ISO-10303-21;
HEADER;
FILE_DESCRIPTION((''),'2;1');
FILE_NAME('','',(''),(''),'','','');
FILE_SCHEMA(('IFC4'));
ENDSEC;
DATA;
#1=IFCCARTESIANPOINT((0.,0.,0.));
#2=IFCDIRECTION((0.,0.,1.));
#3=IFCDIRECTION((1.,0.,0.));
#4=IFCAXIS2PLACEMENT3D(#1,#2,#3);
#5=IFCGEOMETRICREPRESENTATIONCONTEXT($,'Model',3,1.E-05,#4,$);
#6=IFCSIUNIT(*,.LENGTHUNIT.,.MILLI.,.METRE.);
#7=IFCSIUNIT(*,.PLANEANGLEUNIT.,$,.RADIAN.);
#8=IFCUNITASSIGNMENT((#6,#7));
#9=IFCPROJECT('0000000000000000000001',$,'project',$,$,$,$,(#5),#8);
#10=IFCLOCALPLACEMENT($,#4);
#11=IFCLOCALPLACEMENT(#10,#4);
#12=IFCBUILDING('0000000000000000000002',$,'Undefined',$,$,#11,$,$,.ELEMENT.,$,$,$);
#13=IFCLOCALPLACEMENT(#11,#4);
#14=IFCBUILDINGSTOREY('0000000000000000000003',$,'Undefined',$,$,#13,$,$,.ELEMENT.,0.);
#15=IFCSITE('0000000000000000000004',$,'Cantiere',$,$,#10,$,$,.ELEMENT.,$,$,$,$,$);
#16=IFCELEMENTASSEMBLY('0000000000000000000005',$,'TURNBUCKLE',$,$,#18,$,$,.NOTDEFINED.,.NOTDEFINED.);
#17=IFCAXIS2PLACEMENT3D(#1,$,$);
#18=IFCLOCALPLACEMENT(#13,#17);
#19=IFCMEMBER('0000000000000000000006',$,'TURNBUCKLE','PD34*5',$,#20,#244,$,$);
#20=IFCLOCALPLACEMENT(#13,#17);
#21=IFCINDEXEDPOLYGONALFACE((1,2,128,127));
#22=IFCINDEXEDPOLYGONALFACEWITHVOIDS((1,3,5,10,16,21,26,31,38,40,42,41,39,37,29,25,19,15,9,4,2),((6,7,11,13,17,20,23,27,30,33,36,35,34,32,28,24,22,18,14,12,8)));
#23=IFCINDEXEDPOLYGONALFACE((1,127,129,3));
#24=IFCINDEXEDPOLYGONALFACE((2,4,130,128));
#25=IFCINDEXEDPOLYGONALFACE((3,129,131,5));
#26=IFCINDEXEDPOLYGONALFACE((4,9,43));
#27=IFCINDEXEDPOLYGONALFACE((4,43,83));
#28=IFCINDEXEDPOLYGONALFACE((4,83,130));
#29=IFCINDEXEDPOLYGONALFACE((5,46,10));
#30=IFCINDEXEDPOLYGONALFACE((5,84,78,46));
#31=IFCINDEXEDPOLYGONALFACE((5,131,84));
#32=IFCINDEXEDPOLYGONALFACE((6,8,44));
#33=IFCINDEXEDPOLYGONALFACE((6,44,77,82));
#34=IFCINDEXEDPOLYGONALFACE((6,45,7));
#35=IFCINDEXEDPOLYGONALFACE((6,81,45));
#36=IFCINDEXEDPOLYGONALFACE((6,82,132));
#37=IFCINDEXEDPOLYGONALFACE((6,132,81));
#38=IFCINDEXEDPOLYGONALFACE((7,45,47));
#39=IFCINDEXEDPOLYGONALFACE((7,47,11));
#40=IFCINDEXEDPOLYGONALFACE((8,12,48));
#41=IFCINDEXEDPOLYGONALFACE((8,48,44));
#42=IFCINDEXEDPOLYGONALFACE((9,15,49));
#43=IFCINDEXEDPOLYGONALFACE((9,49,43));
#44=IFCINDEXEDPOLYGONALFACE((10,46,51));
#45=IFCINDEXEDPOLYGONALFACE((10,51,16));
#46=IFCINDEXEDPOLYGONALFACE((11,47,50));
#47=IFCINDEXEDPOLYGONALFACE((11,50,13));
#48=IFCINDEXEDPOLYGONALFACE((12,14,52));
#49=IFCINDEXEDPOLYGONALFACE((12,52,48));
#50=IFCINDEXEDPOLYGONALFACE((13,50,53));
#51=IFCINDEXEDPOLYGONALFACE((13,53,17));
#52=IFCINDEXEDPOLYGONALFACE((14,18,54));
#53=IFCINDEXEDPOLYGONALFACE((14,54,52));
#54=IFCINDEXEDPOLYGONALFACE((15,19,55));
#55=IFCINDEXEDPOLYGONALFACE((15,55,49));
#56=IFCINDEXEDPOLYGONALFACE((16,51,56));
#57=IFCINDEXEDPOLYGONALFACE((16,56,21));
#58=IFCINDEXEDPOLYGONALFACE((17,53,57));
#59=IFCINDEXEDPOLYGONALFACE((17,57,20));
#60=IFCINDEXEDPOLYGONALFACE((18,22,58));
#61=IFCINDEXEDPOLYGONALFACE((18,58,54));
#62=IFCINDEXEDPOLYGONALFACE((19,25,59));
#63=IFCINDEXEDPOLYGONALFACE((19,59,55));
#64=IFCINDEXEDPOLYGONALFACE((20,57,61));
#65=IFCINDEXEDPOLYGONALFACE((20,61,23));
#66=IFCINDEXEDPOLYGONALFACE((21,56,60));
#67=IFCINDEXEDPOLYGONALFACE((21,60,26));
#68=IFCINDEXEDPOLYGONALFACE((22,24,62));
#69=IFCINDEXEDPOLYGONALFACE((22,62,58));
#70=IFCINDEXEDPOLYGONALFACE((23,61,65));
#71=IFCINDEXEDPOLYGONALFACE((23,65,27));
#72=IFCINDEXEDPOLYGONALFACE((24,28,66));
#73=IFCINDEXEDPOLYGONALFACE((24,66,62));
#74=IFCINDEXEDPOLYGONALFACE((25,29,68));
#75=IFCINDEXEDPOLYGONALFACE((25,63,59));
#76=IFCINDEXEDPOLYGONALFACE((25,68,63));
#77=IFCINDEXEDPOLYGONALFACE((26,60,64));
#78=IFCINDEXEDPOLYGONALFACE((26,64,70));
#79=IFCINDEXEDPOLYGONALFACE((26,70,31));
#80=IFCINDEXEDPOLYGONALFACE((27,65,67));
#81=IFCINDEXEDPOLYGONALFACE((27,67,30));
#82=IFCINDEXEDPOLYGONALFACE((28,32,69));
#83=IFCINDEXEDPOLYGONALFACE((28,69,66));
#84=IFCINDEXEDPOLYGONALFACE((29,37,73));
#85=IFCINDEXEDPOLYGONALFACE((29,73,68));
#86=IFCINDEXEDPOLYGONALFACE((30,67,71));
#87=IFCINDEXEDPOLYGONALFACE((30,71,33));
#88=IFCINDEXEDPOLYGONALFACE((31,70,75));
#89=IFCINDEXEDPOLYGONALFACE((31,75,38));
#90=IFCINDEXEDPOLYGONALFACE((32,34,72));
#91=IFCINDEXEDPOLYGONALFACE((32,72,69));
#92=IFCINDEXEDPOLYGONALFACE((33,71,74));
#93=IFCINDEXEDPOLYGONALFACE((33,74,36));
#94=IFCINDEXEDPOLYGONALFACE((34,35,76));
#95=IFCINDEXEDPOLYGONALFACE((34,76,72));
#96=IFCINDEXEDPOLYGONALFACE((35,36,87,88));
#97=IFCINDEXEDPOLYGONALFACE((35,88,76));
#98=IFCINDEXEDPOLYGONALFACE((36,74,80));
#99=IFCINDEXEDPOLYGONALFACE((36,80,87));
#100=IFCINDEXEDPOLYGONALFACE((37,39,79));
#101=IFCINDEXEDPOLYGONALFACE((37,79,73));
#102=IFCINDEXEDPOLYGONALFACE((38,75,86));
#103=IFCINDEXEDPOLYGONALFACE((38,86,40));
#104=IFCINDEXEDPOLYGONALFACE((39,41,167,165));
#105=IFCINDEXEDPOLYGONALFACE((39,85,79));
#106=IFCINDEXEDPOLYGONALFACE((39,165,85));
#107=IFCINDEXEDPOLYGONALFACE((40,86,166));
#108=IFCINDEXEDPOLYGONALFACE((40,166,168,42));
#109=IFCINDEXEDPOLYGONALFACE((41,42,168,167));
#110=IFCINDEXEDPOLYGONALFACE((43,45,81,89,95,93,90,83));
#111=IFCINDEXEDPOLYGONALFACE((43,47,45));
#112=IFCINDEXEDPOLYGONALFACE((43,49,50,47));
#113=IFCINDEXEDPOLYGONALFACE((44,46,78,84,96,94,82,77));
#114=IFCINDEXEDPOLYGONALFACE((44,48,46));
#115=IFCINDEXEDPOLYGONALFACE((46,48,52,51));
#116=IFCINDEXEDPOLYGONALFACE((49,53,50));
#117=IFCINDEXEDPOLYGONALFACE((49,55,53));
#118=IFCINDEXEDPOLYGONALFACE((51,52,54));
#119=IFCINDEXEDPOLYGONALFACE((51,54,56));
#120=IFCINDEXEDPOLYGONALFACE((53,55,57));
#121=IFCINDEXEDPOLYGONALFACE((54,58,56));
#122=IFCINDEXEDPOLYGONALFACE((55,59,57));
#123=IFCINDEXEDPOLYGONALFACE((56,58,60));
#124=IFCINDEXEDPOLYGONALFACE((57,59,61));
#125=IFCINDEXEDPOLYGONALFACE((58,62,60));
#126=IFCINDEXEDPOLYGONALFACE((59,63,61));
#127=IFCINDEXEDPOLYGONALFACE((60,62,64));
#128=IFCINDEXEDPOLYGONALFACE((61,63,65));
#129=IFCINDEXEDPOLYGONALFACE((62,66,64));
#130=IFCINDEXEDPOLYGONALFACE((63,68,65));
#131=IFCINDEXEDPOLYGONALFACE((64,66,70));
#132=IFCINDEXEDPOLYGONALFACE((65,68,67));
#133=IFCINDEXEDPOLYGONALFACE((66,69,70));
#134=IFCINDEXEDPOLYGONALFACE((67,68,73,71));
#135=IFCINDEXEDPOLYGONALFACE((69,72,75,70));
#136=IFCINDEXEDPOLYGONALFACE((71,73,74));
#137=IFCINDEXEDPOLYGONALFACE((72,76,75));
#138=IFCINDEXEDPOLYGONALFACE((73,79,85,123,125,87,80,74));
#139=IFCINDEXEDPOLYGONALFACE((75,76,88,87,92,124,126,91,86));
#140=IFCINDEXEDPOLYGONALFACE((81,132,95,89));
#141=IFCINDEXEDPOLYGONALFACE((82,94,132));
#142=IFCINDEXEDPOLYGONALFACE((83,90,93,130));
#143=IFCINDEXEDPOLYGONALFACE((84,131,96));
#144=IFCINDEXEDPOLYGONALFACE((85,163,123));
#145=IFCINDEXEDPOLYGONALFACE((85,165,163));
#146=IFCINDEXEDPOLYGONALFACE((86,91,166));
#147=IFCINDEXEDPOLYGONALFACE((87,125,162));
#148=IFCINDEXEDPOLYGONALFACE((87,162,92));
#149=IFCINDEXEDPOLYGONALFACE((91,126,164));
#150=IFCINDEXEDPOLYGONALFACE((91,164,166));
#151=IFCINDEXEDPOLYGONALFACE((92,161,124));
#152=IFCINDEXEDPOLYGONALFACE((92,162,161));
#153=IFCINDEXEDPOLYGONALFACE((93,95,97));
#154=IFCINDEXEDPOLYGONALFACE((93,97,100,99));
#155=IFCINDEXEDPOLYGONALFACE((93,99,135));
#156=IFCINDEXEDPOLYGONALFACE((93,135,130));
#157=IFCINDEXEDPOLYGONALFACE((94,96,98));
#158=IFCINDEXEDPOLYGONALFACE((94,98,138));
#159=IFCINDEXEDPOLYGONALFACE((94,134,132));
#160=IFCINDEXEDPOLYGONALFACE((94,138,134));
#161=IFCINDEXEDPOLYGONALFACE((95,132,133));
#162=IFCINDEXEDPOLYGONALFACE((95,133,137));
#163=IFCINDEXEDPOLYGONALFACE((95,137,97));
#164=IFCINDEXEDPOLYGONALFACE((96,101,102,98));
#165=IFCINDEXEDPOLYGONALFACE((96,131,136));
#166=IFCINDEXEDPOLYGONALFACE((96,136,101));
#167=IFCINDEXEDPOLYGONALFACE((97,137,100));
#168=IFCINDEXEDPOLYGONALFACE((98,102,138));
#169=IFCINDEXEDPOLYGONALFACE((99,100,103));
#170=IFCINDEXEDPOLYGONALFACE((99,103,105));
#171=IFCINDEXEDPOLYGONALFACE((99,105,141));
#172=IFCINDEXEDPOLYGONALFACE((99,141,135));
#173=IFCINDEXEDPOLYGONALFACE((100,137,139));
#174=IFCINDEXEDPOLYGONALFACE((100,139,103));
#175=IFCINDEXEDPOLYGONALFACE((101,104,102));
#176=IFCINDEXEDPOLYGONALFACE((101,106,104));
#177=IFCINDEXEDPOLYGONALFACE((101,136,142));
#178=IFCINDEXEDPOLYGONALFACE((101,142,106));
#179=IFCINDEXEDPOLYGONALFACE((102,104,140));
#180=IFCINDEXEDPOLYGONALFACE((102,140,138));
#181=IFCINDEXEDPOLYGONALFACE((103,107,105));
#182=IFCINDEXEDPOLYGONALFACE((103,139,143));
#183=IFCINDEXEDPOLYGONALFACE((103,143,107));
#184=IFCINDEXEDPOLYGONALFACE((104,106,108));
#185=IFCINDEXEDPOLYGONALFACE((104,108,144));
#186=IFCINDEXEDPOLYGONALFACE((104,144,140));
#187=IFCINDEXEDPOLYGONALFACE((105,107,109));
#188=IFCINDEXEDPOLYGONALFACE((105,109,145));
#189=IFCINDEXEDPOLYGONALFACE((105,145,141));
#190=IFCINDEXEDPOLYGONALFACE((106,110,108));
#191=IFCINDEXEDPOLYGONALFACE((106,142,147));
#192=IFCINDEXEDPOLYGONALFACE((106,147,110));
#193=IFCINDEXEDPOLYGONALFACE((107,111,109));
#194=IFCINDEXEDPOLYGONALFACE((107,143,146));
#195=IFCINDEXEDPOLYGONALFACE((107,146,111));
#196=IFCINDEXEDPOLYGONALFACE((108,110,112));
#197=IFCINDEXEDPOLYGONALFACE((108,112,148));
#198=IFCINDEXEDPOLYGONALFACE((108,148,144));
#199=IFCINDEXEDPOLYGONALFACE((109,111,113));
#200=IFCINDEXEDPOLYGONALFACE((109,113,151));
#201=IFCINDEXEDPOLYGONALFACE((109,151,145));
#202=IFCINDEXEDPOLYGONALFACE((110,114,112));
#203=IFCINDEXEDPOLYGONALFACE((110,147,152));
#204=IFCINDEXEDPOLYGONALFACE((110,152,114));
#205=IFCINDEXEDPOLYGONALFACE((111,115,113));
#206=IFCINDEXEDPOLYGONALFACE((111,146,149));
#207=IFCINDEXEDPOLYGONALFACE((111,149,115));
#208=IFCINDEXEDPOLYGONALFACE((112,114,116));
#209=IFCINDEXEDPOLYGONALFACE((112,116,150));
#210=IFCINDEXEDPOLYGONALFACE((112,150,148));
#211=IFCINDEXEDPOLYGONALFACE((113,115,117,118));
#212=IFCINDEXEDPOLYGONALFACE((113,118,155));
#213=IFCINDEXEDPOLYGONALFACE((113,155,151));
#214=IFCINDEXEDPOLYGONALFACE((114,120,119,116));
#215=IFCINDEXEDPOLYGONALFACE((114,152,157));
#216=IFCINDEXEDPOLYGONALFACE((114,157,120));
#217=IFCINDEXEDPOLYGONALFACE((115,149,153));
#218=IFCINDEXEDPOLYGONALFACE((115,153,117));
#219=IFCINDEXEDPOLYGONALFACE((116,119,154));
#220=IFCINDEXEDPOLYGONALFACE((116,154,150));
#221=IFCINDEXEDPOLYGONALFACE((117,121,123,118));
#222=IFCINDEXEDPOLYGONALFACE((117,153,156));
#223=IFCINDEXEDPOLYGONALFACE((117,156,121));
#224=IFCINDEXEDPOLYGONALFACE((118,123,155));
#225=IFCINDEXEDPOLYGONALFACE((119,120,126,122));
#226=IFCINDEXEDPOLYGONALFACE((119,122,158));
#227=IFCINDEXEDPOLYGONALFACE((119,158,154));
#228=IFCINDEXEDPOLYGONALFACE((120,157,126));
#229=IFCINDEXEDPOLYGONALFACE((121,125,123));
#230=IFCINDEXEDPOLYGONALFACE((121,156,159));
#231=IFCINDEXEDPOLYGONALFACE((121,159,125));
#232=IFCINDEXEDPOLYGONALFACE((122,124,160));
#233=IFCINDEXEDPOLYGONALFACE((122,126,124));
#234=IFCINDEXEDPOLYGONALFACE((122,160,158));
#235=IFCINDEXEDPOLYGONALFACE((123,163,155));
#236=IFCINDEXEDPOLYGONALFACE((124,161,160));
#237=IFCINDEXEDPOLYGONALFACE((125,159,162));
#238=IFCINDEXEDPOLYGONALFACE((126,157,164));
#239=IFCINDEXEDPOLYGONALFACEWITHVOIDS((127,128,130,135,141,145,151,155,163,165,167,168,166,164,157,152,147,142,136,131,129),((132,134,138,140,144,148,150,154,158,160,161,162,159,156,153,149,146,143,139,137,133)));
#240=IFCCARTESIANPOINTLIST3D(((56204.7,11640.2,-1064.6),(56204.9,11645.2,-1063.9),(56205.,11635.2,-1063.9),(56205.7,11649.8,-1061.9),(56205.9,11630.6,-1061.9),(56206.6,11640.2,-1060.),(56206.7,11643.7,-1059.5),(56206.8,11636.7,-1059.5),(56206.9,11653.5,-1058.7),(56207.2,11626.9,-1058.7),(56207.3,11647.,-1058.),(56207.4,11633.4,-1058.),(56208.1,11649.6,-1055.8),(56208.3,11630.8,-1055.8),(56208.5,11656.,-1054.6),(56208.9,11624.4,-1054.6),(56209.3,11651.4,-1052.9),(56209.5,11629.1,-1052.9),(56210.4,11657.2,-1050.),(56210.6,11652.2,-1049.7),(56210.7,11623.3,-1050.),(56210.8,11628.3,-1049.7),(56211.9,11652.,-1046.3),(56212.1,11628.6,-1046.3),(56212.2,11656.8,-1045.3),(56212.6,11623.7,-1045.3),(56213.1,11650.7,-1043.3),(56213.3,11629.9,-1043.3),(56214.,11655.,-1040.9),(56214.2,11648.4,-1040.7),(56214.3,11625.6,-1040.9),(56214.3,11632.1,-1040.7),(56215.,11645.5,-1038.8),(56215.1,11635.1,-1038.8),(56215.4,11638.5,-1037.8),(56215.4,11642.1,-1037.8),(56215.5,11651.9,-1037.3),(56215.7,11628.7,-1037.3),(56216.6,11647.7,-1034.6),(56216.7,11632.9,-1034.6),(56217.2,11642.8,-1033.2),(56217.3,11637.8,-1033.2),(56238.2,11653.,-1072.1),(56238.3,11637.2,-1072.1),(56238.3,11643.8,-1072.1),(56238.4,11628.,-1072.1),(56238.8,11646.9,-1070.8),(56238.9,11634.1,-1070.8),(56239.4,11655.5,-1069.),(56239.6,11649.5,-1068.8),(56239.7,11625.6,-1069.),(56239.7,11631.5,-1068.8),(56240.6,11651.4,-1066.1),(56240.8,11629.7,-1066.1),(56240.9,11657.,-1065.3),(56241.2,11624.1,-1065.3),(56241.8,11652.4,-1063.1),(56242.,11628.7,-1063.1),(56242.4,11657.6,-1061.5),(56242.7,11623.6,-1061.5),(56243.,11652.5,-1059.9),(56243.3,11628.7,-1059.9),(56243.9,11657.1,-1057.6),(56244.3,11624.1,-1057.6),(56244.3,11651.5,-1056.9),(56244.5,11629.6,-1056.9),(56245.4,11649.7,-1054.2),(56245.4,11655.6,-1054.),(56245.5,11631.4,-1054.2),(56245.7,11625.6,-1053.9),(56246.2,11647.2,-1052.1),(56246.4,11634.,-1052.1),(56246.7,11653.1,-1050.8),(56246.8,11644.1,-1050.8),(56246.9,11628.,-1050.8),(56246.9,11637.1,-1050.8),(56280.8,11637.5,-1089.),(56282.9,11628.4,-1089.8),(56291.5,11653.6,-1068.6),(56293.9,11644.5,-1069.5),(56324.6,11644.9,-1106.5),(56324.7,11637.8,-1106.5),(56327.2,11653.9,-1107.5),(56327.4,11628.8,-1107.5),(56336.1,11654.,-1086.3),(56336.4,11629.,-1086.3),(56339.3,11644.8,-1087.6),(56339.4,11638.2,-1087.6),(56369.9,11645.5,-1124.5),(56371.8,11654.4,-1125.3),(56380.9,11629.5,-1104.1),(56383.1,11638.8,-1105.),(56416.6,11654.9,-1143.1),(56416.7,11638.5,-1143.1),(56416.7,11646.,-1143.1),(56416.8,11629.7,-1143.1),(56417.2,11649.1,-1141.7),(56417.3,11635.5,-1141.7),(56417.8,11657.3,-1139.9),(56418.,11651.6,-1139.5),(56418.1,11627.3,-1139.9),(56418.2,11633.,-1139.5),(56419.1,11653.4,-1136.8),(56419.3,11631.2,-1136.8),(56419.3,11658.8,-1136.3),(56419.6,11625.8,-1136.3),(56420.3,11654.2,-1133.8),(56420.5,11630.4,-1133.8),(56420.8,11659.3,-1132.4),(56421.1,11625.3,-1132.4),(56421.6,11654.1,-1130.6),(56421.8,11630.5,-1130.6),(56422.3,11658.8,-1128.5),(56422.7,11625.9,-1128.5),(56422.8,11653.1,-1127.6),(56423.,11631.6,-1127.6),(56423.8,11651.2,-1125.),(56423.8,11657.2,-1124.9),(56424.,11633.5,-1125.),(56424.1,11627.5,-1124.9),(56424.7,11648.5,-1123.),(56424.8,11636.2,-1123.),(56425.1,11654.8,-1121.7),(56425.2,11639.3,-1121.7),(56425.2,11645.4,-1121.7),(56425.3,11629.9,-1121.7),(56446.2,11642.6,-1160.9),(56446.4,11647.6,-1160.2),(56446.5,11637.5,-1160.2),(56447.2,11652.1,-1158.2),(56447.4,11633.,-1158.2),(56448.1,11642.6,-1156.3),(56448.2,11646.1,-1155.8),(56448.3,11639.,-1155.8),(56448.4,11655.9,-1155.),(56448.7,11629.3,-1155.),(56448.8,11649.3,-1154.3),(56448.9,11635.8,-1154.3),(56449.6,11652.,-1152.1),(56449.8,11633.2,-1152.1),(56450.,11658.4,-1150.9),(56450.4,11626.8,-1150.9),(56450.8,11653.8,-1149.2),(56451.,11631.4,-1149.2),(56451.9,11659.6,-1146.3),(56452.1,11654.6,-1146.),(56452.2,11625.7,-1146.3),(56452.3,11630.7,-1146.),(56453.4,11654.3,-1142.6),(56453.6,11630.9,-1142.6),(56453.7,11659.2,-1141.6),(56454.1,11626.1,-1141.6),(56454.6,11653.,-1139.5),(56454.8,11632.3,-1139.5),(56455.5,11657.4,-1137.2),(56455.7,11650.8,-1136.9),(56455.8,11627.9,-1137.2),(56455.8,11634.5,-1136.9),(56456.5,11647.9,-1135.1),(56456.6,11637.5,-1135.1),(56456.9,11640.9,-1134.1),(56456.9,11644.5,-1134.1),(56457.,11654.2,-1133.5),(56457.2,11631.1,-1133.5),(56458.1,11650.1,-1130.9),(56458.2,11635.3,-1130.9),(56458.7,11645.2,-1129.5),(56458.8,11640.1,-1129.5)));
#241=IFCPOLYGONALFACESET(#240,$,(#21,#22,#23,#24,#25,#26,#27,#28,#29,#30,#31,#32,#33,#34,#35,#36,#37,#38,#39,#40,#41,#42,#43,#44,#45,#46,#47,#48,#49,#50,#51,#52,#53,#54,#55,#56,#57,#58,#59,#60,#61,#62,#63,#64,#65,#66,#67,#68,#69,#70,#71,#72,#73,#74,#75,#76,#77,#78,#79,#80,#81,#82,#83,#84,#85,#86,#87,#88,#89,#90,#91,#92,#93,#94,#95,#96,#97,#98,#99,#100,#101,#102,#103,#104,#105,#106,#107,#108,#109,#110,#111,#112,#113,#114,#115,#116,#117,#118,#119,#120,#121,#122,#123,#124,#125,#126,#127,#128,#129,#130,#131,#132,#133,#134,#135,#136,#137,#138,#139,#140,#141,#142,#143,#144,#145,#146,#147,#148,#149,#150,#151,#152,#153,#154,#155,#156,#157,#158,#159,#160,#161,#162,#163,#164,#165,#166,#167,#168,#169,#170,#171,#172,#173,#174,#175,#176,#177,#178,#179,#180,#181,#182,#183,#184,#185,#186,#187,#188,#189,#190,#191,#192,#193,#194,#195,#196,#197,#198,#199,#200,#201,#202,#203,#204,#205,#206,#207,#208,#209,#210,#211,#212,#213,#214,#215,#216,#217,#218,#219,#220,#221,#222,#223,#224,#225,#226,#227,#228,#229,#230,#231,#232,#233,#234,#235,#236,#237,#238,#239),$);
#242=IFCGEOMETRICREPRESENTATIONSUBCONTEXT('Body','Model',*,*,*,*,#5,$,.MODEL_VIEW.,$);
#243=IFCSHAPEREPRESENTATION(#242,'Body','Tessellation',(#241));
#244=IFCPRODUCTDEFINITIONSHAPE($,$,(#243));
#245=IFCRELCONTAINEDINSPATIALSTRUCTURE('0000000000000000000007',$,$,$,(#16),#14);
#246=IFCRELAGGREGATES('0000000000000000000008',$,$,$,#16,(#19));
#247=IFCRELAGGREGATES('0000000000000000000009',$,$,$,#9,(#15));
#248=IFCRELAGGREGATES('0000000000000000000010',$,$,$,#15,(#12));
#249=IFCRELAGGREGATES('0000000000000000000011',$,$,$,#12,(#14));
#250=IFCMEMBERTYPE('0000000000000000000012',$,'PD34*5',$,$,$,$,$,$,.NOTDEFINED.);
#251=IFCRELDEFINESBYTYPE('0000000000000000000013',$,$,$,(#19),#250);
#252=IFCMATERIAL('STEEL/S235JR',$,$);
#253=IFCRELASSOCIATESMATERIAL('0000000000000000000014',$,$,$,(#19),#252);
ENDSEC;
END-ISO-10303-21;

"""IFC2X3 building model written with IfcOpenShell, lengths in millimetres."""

from ifc_helpers import new_model, si_unit, frame, origin_with_axes, origin_2d_with_axis, place, context, subcontext, project, spatial, rectangle, hollow_circle, extrude, boolean, material, type_object, element, aggregate, save


model = new_model("IFC2X3")

# Units and contexts
model_context = context("Model", 3, precision=1e-05, world=origin_with_axes())
body_context = subcontext(model_context, "Body", "Model", "MODEL_VIEW")
ifc_project = project(units=[si_unit("LENGTHUNIT", "METRE", prefix="MILLI"), si_unit("PLANEANGLEUNIT", "RADIAN")], contexts=[model_context])

# Site, building, storey
site_placement = place(None, origin_with_axes())
site = spatial("IfcSite", under=ifc_project, at=site_placement, Name="Cantiere", CompositionType="ELEMENT")
building_placement = place(site_placement, origin_with_axes())
building = spatial("IfcBuilding", under=site, at=building_placement, Name="Undefined", CompositionType="ELEMENT")
storey_placement = place(building_placement, origin_with_axes())
storey = spatial("IfcBuildingStorey", under=building, at=storey_placement, Name="Undefined", CompositionType="ELEMENT", Elevation=0.0)

# Shared definitions
ifc_material_1 = material(Name="STEEL/S235JR")

# Element assembly, member
assembly_1_placement = place(storey_placement, origin_with_axes())
assembly_1 = element("IfcElementAssembly", 1, at=assembly_1_placement, inside=storey, Name="TURNBUCKLE", AssemblyPlace="NOTDEFINED", PredefinedType="NOTDEFINED")
member_type = type_object("IfcMemberType", Name="PD34*5", PredefinedType="NOTDEFINED")
member_placement = place(assembly_1_placement, frame((56452.5, 11642.6, -1145.1), z_axis=(-0.009871, 0.999951, -0.000051), x_axis=(-0.92885, -0.00915, 0.370342)))
member = element("IfcMember", 2, at=member_placement, type_object=member_type, material=ifc_material_1, Name="TURNBUCKLE", Description="PD34*5", context=body_context, shape_type="CSG", body=[
    boolean("DIFFERENCE", extrude(hollow_circle(Radius=17.0, WallThickness=5.0, at=origin_2d_with_axis()), frame((260.0, 0.0, 0.0), z_axis=(-1.0, 0.0, 0.0), x_axis=(0.0, -1.0, 0.0)), (0.0, 0.0, 1.0), 260.0), extrude(rectangle(XDim=23.0, YDim=68.0, at=origin_2d_with_axis()), frame((226.0, 0.0, 0.0), z_axis=(-1.0, 0.000733, 0.0), x_axis=(-0.000733, -1.0, 0.0)), (0.0, 0.0, 1.0), 192.0)),
])
aggregate(assembly_1, [member])

save(model, "model.ifc")
